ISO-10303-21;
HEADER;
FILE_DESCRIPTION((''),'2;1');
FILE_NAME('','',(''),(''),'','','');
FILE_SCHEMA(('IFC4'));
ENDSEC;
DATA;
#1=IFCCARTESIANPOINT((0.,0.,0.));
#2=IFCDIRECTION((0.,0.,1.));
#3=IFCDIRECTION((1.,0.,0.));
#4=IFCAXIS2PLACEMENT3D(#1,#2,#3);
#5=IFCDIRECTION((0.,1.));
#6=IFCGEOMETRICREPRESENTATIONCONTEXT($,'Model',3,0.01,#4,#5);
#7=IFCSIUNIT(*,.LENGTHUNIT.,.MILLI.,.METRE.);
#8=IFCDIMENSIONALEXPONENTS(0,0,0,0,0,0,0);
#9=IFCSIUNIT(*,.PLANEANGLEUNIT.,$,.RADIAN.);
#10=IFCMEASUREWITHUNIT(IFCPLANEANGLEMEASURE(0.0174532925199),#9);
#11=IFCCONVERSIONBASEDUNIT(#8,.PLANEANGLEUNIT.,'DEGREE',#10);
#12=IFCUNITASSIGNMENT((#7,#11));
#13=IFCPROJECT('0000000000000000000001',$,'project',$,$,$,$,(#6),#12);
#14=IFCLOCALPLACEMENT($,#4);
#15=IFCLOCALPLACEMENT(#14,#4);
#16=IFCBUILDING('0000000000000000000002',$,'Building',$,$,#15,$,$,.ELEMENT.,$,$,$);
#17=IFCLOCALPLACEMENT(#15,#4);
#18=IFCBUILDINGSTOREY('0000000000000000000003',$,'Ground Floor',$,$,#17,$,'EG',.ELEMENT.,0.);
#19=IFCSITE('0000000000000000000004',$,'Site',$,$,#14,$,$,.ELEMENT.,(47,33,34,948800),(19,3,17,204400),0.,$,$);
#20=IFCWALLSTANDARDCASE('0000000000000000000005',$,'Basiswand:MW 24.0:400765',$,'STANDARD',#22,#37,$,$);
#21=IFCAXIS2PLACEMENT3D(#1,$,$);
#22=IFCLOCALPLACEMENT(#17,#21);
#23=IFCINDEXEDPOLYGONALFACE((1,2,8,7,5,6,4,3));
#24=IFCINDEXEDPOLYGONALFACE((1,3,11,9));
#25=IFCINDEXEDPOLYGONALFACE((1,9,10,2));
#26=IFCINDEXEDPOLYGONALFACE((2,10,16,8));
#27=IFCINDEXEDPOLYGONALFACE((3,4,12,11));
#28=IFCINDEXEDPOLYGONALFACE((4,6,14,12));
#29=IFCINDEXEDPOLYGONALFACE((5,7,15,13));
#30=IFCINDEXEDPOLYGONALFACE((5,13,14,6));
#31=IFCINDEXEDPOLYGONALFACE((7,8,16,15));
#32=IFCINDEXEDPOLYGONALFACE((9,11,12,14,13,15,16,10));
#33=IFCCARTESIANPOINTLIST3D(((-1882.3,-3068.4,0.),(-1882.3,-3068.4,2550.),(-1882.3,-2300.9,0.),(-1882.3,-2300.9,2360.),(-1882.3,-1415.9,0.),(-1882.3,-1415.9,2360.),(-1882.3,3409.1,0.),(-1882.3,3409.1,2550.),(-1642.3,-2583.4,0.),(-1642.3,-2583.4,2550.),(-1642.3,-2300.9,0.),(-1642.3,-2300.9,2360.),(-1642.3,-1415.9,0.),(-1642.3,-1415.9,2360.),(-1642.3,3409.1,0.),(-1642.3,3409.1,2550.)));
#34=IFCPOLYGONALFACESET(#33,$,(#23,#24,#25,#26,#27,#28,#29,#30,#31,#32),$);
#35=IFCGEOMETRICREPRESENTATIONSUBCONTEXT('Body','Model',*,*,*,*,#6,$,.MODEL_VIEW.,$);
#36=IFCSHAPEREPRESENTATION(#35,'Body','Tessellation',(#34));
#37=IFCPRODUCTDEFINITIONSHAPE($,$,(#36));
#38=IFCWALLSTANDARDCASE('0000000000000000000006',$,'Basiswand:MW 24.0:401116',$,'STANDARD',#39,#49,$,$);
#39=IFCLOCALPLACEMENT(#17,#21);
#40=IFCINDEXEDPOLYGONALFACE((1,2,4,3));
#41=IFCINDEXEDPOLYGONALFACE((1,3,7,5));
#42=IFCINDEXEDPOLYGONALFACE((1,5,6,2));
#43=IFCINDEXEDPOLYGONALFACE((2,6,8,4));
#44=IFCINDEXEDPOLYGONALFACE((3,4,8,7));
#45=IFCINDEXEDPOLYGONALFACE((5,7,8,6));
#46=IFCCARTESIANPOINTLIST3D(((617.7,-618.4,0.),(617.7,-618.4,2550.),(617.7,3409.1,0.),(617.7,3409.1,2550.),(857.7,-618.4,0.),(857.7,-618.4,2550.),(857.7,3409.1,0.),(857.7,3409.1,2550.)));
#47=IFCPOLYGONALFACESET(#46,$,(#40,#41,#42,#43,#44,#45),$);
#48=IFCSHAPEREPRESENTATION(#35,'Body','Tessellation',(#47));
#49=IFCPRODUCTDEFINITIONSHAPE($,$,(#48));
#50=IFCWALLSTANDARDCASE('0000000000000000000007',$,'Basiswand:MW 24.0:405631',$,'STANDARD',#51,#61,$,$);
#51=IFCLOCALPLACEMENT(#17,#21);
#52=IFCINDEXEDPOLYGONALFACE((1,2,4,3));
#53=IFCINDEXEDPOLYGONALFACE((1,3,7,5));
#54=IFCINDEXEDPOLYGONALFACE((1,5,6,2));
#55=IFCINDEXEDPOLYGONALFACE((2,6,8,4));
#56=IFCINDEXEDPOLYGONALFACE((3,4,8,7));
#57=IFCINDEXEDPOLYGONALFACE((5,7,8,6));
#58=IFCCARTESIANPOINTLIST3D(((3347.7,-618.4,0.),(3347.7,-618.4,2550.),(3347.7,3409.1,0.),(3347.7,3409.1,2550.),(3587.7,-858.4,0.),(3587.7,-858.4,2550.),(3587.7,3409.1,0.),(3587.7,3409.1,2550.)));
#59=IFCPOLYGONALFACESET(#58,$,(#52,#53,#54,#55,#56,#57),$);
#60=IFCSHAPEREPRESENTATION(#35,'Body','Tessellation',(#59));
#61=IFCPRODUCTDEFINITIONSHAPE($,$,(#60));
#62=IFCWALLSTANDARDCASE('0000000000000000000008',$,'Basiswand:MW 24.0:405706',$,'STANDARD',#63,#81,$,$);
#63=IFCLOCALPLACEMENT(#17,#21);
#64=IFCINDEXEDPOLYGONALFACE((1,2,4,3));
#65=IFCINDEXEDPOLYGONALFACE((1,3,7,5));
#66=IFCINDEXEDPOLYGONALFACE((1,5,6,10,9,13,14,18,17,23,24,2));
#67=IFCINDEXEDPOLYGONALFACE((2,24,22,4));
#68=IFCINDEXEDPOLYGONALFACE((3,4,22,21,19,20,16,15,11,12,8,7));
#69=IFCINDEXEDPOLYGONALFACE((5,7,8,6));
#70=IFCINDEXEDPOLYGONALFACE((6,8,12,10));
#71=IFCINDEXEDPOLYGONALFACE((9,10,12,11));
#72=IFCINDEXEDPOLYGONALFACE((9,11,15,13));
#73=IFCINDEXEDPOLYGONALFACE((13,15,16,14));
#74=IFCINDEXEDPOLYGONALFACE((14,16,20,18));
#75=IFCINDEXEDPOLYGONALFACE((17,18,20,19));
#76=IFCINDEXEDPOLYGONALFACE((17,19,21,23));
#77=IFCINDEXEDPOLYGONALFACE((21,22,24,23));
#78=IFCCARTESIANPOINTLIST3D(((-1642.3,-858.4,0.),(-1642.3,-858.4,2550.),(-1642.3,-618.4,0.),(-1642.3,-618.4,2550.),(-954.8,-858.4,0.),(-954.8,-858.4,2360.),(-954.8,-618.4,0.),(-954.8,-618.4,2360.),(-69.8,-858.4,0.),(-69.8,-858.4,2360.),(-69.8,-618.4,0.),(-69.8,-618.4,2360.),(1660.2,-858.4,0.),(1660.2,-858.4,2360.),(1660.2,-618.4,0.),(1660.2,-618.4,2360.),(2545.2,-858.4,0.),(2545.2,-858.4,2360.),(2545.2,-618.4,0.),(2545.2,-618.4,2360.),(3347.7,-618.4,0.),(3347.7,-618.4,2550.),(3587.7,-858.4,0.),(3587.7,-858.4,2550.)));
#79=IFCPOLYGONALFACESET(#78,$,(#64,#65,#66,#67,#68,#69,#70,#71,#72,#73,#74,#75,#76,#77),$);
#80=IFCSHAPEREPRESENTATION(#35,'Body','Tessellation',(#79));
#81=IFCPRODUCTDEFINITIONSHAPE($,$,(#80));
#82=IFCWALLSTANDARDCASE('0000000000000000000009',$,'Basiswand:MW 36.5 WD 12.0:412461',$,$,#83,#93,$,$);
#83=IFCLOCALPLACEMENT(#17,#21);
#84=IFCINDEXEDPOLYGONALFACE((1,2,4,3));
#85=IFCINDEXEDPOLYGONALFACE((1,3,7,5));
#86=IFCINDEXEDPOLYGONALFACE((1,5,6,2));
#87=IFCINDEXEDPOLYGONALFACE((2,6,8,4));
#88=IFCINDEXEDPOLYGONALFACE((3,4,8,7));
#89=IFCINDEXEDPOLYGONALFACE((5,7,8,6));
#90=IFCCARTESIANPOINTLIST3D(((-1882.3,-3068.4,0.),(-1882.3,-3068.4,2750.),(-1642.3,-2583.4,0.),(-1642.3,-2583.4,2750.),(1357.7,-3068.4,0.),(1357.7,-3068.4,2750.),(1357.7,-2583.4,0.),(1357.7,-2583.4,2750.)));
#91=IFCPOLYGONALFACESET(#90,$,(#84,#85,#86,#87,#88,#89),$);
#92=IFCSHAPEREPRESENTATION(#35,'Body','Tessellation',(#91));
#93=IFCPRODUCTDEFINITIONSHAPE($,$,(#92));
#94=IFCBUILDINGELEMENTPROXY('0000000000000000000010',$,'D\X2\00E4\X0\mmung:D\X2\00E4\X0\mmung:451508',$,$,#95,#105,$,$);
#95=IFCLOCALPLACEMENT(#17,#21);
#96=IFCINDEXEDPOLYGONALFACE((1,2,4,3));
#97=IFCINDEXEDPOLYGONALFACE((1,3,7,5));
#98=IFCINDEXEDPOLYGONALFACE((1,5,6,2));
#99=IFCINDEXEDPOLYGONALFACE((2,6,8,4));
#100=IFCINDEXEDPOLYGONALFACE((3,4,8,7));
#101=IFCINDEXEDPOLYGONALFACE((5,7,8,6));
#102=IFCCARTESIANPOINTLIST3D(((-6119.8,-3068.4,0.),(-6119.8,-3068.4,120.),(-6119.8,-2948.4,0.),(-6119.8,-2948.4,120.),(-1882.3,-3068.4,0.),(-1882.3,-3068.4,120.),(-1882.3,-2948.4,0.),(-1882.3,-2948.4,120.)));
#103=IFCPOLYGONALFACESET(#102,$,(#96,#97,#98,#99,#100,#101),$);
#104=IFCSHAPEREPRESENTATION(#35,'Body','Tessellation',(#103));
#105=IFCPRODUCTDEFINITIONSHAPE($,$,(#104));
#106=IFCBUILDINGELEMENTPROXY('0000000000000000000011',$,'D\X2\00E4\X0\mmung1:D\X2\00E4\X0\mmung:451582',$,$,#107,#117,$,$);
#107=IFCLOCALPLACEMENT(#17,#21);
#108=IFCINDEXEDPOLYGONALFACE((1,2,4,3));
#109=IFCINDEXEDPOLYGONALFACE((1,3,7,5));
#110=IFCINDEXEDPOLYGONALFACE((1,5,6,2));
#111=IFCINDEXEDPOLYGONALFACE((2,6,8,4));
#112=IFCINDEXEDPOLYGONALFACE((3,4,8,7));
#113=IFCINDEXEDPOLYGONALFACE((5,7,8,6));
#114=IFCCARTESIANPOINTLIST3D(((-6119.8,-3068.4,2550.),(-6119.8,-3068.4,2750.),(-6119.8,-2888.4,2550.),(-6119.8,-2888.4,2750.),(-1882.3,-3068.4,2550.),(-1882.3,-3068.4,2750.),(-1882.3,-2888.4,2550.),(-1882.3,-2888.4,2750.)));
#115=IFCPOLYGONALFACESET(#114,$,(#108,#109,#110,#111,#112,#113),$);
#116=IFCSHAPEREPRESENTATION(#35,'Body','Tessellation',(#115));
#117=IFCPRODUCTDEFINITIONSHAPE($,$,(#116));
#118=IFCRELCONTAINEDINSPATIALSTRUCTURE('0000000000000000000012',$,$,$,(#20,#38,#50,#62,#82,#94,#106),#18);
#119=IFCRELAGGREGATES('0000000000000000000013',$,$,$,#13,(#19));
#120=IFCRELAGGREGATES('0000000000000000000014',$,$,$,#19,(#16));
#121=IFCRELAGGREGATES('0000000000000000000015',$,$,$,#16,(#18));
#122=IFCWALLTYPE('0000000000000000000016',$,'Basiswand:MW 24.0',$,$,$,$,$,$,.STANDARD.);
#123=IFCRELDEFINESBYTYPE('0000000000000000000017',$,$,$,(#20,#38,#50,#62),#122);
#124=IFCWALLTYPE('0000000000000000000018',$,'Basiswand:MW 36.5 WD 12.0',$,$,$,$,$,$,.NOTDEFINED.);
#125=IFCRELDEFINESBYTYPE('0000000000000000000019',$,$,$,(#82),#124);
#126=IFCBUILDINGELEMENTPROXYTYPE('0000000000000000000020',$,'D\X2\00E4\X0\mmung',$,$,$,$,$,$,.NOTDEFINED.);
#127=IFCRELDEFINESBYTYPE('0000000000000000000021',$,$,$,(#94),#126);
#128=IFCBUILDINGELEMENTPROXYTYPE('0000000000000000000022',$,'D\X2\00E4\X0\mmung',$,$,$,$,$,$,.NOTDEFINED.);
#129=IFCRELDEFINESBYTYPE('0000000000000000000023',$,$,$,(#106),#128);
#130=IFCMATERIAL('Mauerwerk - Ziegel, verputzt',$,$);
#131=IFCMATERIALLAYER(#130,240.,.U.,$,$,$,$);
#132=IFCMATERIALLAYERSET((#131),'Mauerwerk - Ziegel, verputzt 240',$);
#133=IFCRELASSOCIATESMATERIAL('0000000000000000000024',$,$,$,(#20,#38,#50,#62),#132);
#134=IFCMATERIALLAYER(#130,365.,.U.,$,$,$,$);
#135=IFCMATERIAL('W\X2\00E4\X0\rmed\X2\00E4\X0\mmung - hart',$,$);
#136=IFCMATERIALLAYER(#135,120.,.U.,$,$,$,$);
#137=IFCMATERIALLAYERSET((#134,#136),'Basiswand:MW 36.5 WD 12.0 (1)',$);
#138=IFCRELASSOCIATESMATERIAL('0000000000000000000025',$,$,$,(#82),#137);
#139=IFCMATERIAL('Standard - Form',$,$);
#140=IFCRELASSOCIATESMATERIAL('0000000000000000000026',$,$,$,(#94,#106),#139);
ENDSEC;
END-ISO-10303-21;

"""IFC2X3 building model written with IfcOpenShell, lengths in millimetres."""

from ifc_helpers import new_model, entity, si_unit, converted_unit, direction, frame, origin_with_axes, origin_2d_with_axis, place, context, subcontext, project, spatial, polyline, rectangle, outline, extrude, material, layer, layer_set, layer_usage, type_object, element, save


model = new_model("IFC2X3")

# Units and contexts
model_context = context("Model", 3, precision=0.01, world=origin_with_axes(), true_north=direction((0.0, 1.0)))
body_context = subcontext(model_context, "Body", "Model", "MODEL_VIEW")
ifc_project = project(units=[si_unit("LENGTHUNIT", "METRE", prefix="MILLI"), converted_unit("PLANEANGLEUNIT", "DEGREE", entity("IfcPlaneAngleMeasure", 0.0174532925199), si_unit("PLANEANGLEUNIT", "RADIAN"), dimensions=[0, 0, 0, 0, 0, 0, 0])], contexts=[model_context])

# Site, building, storey
site_placement = place(None, origin_with_axes())
site = spatial("IfcSite", under=ifc_project, at=site_placement, Name="Site", CompositionType="ELEMENT", RefLatitude=(47, 33, 34, 948800), RefLongitude=(19, 3, 17, 204400), RefElevation=0.0)
building_placement = place(site_placement, origin_with_axes())
building = spatial("IfcBuilding", under=site, at=building_placement, Name="Building", CompositionType="ELEMENT")
storey_placement = place(building_placement, origin_with_axes())
storey = spatial("IfcBuildingStorey", under=building, at=storey_placement, Name="Ground Floor", LongName="EG", CompositionType="ELEMENT", Elevation=0.0)

# Wall, opening
ifc_material_1 = material(Name="Mauerwerk - Ziegel, verputzt")
ifc_layer_1 = layer(ifc_material_1, 240.0, ventilated="UNKNOWN")
ifc_layer_set_1 = layer_set([ifc_layer_1], Name="Mauerwerk - Ziegel, verputzt 240")
ifc_layer_usage_1 = layer_usage(ifc_layer_set_1, "AXIS2", "POSITIVE", -120.0)
wall_type_1 = type_object("IfcWallType", Name="Basiswand:MW 24.0", PredefinedType="STANDARD")
wall_1_placement = place(storey_placement, frame((-1762.3, 3409.1, 0.0), z_axis=(0.0, 0.0, 1.0), x_axis=(0.0, -1.0, 0.0)))
wall_1 = element("IfcWallStandardCase", 1, at=wall_1_placement, inside=storey, type_object=wall_type_1, material=ifc_layer_usage_1, Name="Basiswand:MW 24.0:400765", ObjectType="STANDARD", context=body_context, shape_type="SweptSolid", body=[
    extrude(outline(polyline([(0.0, -120.0), (6477.5, -120.0), (5992.5, 120.0), (0.0, 120.0), (0.0, -120.0)])), origin_with_axes(), (0.0, 0.0, 1.0), 2550.0),
])
opening_1_placement = place(wall_1_placement, frame((5267.5, 0.0, 0.0), z_axis=(0.0, 0.0, 1.0), x_axis=(1.0, 0.0, 0.0)))
element("IfcOpeningElement", 2, at=opening_1_placement, cuts=wall_1, context=body_context, shape_type="SweptSolid", body=[
    extrude(outline(polyline([(-442.5, -2360.0), (442.5, -2360.0), (442.5, 0.0), (-442.5, 0.0), (-442.5, -2360.0)])), frame((0.0, 120.0, 0.0), z_axis=(0.0, -1.0, 0.0), x_axis=(-1.0, 0.0, 0.0)), (0.0, 0.0, 1.0), 240.0),
])

# Walls
ifc_layer_usage_2 = layer_usage(ifc_layer_set_1, "AXIS2", "POSITIVE", -120.0)
wall_2_placement = place(storey_placement, frame((737.7, 3409.1, 0.0), z_axis=(0.0, 0.0, 1.0), x_axis=(0.0, -1.0, 0.0)))
element("IfcWallStandardCase", 3, at=wall_2_placement, inside=storey, type_object=wall_type_1, material=ifc_layer_usage_2, Name="Basiswand:MW 24.0:401116", ObjectType="STANDARD", context=body_context, shape_type="SweptSolid", body=[
    extrude(outline(polyline([(0.0, -120.0), (4027.5, -120.0), (4027.5, 120.0), (0.0, 120.0), (0.0, -120.0)])), origin_with_axes(), (0.0, 0.0, 1.0), 2550.0),
])
ifc_layer_usage_3 = layer_usage(ifc_layer_set_1, "AXIS2", "POSITIVE", -120.0)
wall_3_placement = place(storey_placement, frame((3467.7, 3409.1, 0.0), z_axis=(0.0, 0.0, 1.0), x_axis=(0.0, -1.0, 0.0)))
element("IfcWallStandardCase", 4, at=wall_3_placement, inside=storey, type_object=wall_type_1, material=ifc_layer_usage_3, Name="Basiswand:MW 24.0:405631", ObjectType="STANDARD", context=body_context, shape_type="SweptSolid", body=[
    extrude(outline(polyline([(0.0, -120.0), (4027.5, -120.0), (4267.5, 120.0), (0.0, 120.0), (0.0, -120.0)])), origin_with_axes(), (0.0, 0.0, 1.0), 2550.0),
])

# Wall, openings
ifc_layer_usage_4 = layer_usage(ifc_layer_set_1, "AXIS2", "POSITIVE", -120.0)
wall_4_placement = place(storey_placement, frame((3467.7, -738.4, 0.0), z_axis=(0.0, 0.0, 1.0), x_axis=(-1.0, 0.0, 0.0)))
wall_4 = element("IfcWallStandardCase", 5, at=wall_4_placement, inside=storey, type_object=wall_type_1, material=ifc_layer_usage_4, Name="Basiswand:MW 24.0:405706", ObjectType="STANDARD", context=body_context, shape_type="SweptSolid", body=[
    extrude(outline(polyline([(120.0, -120.0), (5110.0, -120.0), (5110.0, 120.0), (-120.0, 120.0), (120.0, -120.0)])), origin_with_axes(), (0.0, 0.0, 1.0), 2550.0),
])
opening_2_placement = place(wall_4_placement, frame((1365.0, 0.0, 0.0), z_axis=(0.0, 0.0, 1.0), x_axis=(1.0, 0.0, 0.0)))
element("IfcOpeningElement", 6, at=opening_2_placement, cuts=wall_4, context=body_context, shape_type="SweptSolid", body=[
    extrude(outline(polyline([(-442.5, -2360.0), (442.5, -2360.0), (442.5, 0.0), (-442.5, 0.0), (-442.5, -2360.0)])), frame((0.0, 120.0, 0.0), z_axis=(0.0, -1.0, 0.0), x_axis=(-1.0, 0.0, 0.0)), (0.0, 0.0, 1.0), 240.0),
])
opening_3_placement = place(wall_4_placement, frame((3980.0, 0.0, 0.0), z_axis=(0.0, 0.0, 1.0), x_axis=(1.0, 0.0, 0.0)))
element("IfcOpeningElement", 7, at=opening_3_placement, cuts=wall_4, context=body_context, shape_type="SweptSolid", body=[
    extrude(outline(polyline([(-442.5, -2360.0), (442.5, -2360.0), (442.5, 0.0), (-442.5, 0.0), (-442.5, -2360.0)])), frame((0.0, 120.0, 0.0), z_axis=(0.0, -1.0, 0.0), x_axis=(-1.0, 0.0, 0.0)), (0.0, 0.0, 1.0), 240.0),
])

# Wall
ifc_layer_2 = layer(ifc_material_1, 365.0, ventilated="UNKNOWN")
ifc_material_2 = material(Name="Wärmedämmung - hart")
ifc_layer_3 = layer(ifc_material_2, 120.0, ventilated="UNKNOWN")
ifc_layer_set_2 = layer_set([ifc_layer_2, ifc_layer_3], Name="Basiswand:MW 36.5 WD 12.0 (1)")
ifc_layer_usage_5 = layer_usage(ifc_layer_set_2, "AXIS2", "POSITIVE", -242.5)
wall_type_2 = type_object("IfcWallType", Name="Basiswand:MW 36.5 WD 12.0", PredefinedType="NOTDEFINED")
wall_5_placement = place(storey_placement, frame((1357.7, -2825.9, 0.0), z_axis=(0.0, 0.0, 1.0), x_axis=(-1.0, 0.0, 0.0)))
element("IfcWallStandardCase", 8, at=wall_5_placement, inside=storey, type_object=wall_type_2, material=ifc_layer_usage_5, Name="Basiswand:MW 36.5 WD 12.0:412461", context=body_context, shape_type="SweptSolid", body=[
    extrude(outline(polyline([(0.0, -242.5), (3000.0, -242.5), (3240.0, 242.5), (0.0, 242.5), (0.0, -242.5)])), origin_with_axes(), (0.0, 0.0, 1.0), 2750.0),
])

# Building element proxies
ifc_material_3 = material(Name="Standard - Form")
building_element_proxy_type_1 = type_object("IfcBuildingElementProxyType", Name="Dämmung", PredefinedType="NOTDEFINED")
proxy_1_placement = place(storey_placement, origin_with_axes())
element("IfcBuildingElementProxy", 9, at=proxy_1_placement, inside=storey, type_object=building_element_proxy_type_1, material=ifc_material_3, Name="Dämmung:Dämmung:451508", context=body_context, shape_type="SweptSolid", body=[
    extrude(rectangle(XDim=4237.5, YDim=120.0, at=origin_2d_with_axis()), frame((-4001.0, -3008.4, 0.0), z_axis=(0.0, 0.0, 1.0), x_axis=(-1.0, 0.0, 0.0)), (0.0, 0.0, 1.0), 120.0),
])
building_element_proxy_type_2 = type_object("IfcBuildingElementProxyType", Name="Dämmung", PredefinedType="NOTDEFINED")
proxy_2_placement = place(storey_placement, origin_with_axes())
element("IfcBuildingElementProxy", 10, at=proxy_2_placement, inside=storey, type_object=building_element_proxy_type_2, material=ifc_material_3, Name="Dämmung1:Dämmung:451582", context=body_context, shape_type="SweptSolid", body=[
    extrude(rectangle(XDim=180.0, YDim=4237.5, at=origin_2d_with_axis()), frame((-4001.0, -2978.4, 2550.0), z_axis=(0.0, 0.0, 1.0), x_axis=(0.0, -1.0, 0.0)), (0.0, 0.0, 1.0), 200.0),
])

save(model, "model.ifc")
